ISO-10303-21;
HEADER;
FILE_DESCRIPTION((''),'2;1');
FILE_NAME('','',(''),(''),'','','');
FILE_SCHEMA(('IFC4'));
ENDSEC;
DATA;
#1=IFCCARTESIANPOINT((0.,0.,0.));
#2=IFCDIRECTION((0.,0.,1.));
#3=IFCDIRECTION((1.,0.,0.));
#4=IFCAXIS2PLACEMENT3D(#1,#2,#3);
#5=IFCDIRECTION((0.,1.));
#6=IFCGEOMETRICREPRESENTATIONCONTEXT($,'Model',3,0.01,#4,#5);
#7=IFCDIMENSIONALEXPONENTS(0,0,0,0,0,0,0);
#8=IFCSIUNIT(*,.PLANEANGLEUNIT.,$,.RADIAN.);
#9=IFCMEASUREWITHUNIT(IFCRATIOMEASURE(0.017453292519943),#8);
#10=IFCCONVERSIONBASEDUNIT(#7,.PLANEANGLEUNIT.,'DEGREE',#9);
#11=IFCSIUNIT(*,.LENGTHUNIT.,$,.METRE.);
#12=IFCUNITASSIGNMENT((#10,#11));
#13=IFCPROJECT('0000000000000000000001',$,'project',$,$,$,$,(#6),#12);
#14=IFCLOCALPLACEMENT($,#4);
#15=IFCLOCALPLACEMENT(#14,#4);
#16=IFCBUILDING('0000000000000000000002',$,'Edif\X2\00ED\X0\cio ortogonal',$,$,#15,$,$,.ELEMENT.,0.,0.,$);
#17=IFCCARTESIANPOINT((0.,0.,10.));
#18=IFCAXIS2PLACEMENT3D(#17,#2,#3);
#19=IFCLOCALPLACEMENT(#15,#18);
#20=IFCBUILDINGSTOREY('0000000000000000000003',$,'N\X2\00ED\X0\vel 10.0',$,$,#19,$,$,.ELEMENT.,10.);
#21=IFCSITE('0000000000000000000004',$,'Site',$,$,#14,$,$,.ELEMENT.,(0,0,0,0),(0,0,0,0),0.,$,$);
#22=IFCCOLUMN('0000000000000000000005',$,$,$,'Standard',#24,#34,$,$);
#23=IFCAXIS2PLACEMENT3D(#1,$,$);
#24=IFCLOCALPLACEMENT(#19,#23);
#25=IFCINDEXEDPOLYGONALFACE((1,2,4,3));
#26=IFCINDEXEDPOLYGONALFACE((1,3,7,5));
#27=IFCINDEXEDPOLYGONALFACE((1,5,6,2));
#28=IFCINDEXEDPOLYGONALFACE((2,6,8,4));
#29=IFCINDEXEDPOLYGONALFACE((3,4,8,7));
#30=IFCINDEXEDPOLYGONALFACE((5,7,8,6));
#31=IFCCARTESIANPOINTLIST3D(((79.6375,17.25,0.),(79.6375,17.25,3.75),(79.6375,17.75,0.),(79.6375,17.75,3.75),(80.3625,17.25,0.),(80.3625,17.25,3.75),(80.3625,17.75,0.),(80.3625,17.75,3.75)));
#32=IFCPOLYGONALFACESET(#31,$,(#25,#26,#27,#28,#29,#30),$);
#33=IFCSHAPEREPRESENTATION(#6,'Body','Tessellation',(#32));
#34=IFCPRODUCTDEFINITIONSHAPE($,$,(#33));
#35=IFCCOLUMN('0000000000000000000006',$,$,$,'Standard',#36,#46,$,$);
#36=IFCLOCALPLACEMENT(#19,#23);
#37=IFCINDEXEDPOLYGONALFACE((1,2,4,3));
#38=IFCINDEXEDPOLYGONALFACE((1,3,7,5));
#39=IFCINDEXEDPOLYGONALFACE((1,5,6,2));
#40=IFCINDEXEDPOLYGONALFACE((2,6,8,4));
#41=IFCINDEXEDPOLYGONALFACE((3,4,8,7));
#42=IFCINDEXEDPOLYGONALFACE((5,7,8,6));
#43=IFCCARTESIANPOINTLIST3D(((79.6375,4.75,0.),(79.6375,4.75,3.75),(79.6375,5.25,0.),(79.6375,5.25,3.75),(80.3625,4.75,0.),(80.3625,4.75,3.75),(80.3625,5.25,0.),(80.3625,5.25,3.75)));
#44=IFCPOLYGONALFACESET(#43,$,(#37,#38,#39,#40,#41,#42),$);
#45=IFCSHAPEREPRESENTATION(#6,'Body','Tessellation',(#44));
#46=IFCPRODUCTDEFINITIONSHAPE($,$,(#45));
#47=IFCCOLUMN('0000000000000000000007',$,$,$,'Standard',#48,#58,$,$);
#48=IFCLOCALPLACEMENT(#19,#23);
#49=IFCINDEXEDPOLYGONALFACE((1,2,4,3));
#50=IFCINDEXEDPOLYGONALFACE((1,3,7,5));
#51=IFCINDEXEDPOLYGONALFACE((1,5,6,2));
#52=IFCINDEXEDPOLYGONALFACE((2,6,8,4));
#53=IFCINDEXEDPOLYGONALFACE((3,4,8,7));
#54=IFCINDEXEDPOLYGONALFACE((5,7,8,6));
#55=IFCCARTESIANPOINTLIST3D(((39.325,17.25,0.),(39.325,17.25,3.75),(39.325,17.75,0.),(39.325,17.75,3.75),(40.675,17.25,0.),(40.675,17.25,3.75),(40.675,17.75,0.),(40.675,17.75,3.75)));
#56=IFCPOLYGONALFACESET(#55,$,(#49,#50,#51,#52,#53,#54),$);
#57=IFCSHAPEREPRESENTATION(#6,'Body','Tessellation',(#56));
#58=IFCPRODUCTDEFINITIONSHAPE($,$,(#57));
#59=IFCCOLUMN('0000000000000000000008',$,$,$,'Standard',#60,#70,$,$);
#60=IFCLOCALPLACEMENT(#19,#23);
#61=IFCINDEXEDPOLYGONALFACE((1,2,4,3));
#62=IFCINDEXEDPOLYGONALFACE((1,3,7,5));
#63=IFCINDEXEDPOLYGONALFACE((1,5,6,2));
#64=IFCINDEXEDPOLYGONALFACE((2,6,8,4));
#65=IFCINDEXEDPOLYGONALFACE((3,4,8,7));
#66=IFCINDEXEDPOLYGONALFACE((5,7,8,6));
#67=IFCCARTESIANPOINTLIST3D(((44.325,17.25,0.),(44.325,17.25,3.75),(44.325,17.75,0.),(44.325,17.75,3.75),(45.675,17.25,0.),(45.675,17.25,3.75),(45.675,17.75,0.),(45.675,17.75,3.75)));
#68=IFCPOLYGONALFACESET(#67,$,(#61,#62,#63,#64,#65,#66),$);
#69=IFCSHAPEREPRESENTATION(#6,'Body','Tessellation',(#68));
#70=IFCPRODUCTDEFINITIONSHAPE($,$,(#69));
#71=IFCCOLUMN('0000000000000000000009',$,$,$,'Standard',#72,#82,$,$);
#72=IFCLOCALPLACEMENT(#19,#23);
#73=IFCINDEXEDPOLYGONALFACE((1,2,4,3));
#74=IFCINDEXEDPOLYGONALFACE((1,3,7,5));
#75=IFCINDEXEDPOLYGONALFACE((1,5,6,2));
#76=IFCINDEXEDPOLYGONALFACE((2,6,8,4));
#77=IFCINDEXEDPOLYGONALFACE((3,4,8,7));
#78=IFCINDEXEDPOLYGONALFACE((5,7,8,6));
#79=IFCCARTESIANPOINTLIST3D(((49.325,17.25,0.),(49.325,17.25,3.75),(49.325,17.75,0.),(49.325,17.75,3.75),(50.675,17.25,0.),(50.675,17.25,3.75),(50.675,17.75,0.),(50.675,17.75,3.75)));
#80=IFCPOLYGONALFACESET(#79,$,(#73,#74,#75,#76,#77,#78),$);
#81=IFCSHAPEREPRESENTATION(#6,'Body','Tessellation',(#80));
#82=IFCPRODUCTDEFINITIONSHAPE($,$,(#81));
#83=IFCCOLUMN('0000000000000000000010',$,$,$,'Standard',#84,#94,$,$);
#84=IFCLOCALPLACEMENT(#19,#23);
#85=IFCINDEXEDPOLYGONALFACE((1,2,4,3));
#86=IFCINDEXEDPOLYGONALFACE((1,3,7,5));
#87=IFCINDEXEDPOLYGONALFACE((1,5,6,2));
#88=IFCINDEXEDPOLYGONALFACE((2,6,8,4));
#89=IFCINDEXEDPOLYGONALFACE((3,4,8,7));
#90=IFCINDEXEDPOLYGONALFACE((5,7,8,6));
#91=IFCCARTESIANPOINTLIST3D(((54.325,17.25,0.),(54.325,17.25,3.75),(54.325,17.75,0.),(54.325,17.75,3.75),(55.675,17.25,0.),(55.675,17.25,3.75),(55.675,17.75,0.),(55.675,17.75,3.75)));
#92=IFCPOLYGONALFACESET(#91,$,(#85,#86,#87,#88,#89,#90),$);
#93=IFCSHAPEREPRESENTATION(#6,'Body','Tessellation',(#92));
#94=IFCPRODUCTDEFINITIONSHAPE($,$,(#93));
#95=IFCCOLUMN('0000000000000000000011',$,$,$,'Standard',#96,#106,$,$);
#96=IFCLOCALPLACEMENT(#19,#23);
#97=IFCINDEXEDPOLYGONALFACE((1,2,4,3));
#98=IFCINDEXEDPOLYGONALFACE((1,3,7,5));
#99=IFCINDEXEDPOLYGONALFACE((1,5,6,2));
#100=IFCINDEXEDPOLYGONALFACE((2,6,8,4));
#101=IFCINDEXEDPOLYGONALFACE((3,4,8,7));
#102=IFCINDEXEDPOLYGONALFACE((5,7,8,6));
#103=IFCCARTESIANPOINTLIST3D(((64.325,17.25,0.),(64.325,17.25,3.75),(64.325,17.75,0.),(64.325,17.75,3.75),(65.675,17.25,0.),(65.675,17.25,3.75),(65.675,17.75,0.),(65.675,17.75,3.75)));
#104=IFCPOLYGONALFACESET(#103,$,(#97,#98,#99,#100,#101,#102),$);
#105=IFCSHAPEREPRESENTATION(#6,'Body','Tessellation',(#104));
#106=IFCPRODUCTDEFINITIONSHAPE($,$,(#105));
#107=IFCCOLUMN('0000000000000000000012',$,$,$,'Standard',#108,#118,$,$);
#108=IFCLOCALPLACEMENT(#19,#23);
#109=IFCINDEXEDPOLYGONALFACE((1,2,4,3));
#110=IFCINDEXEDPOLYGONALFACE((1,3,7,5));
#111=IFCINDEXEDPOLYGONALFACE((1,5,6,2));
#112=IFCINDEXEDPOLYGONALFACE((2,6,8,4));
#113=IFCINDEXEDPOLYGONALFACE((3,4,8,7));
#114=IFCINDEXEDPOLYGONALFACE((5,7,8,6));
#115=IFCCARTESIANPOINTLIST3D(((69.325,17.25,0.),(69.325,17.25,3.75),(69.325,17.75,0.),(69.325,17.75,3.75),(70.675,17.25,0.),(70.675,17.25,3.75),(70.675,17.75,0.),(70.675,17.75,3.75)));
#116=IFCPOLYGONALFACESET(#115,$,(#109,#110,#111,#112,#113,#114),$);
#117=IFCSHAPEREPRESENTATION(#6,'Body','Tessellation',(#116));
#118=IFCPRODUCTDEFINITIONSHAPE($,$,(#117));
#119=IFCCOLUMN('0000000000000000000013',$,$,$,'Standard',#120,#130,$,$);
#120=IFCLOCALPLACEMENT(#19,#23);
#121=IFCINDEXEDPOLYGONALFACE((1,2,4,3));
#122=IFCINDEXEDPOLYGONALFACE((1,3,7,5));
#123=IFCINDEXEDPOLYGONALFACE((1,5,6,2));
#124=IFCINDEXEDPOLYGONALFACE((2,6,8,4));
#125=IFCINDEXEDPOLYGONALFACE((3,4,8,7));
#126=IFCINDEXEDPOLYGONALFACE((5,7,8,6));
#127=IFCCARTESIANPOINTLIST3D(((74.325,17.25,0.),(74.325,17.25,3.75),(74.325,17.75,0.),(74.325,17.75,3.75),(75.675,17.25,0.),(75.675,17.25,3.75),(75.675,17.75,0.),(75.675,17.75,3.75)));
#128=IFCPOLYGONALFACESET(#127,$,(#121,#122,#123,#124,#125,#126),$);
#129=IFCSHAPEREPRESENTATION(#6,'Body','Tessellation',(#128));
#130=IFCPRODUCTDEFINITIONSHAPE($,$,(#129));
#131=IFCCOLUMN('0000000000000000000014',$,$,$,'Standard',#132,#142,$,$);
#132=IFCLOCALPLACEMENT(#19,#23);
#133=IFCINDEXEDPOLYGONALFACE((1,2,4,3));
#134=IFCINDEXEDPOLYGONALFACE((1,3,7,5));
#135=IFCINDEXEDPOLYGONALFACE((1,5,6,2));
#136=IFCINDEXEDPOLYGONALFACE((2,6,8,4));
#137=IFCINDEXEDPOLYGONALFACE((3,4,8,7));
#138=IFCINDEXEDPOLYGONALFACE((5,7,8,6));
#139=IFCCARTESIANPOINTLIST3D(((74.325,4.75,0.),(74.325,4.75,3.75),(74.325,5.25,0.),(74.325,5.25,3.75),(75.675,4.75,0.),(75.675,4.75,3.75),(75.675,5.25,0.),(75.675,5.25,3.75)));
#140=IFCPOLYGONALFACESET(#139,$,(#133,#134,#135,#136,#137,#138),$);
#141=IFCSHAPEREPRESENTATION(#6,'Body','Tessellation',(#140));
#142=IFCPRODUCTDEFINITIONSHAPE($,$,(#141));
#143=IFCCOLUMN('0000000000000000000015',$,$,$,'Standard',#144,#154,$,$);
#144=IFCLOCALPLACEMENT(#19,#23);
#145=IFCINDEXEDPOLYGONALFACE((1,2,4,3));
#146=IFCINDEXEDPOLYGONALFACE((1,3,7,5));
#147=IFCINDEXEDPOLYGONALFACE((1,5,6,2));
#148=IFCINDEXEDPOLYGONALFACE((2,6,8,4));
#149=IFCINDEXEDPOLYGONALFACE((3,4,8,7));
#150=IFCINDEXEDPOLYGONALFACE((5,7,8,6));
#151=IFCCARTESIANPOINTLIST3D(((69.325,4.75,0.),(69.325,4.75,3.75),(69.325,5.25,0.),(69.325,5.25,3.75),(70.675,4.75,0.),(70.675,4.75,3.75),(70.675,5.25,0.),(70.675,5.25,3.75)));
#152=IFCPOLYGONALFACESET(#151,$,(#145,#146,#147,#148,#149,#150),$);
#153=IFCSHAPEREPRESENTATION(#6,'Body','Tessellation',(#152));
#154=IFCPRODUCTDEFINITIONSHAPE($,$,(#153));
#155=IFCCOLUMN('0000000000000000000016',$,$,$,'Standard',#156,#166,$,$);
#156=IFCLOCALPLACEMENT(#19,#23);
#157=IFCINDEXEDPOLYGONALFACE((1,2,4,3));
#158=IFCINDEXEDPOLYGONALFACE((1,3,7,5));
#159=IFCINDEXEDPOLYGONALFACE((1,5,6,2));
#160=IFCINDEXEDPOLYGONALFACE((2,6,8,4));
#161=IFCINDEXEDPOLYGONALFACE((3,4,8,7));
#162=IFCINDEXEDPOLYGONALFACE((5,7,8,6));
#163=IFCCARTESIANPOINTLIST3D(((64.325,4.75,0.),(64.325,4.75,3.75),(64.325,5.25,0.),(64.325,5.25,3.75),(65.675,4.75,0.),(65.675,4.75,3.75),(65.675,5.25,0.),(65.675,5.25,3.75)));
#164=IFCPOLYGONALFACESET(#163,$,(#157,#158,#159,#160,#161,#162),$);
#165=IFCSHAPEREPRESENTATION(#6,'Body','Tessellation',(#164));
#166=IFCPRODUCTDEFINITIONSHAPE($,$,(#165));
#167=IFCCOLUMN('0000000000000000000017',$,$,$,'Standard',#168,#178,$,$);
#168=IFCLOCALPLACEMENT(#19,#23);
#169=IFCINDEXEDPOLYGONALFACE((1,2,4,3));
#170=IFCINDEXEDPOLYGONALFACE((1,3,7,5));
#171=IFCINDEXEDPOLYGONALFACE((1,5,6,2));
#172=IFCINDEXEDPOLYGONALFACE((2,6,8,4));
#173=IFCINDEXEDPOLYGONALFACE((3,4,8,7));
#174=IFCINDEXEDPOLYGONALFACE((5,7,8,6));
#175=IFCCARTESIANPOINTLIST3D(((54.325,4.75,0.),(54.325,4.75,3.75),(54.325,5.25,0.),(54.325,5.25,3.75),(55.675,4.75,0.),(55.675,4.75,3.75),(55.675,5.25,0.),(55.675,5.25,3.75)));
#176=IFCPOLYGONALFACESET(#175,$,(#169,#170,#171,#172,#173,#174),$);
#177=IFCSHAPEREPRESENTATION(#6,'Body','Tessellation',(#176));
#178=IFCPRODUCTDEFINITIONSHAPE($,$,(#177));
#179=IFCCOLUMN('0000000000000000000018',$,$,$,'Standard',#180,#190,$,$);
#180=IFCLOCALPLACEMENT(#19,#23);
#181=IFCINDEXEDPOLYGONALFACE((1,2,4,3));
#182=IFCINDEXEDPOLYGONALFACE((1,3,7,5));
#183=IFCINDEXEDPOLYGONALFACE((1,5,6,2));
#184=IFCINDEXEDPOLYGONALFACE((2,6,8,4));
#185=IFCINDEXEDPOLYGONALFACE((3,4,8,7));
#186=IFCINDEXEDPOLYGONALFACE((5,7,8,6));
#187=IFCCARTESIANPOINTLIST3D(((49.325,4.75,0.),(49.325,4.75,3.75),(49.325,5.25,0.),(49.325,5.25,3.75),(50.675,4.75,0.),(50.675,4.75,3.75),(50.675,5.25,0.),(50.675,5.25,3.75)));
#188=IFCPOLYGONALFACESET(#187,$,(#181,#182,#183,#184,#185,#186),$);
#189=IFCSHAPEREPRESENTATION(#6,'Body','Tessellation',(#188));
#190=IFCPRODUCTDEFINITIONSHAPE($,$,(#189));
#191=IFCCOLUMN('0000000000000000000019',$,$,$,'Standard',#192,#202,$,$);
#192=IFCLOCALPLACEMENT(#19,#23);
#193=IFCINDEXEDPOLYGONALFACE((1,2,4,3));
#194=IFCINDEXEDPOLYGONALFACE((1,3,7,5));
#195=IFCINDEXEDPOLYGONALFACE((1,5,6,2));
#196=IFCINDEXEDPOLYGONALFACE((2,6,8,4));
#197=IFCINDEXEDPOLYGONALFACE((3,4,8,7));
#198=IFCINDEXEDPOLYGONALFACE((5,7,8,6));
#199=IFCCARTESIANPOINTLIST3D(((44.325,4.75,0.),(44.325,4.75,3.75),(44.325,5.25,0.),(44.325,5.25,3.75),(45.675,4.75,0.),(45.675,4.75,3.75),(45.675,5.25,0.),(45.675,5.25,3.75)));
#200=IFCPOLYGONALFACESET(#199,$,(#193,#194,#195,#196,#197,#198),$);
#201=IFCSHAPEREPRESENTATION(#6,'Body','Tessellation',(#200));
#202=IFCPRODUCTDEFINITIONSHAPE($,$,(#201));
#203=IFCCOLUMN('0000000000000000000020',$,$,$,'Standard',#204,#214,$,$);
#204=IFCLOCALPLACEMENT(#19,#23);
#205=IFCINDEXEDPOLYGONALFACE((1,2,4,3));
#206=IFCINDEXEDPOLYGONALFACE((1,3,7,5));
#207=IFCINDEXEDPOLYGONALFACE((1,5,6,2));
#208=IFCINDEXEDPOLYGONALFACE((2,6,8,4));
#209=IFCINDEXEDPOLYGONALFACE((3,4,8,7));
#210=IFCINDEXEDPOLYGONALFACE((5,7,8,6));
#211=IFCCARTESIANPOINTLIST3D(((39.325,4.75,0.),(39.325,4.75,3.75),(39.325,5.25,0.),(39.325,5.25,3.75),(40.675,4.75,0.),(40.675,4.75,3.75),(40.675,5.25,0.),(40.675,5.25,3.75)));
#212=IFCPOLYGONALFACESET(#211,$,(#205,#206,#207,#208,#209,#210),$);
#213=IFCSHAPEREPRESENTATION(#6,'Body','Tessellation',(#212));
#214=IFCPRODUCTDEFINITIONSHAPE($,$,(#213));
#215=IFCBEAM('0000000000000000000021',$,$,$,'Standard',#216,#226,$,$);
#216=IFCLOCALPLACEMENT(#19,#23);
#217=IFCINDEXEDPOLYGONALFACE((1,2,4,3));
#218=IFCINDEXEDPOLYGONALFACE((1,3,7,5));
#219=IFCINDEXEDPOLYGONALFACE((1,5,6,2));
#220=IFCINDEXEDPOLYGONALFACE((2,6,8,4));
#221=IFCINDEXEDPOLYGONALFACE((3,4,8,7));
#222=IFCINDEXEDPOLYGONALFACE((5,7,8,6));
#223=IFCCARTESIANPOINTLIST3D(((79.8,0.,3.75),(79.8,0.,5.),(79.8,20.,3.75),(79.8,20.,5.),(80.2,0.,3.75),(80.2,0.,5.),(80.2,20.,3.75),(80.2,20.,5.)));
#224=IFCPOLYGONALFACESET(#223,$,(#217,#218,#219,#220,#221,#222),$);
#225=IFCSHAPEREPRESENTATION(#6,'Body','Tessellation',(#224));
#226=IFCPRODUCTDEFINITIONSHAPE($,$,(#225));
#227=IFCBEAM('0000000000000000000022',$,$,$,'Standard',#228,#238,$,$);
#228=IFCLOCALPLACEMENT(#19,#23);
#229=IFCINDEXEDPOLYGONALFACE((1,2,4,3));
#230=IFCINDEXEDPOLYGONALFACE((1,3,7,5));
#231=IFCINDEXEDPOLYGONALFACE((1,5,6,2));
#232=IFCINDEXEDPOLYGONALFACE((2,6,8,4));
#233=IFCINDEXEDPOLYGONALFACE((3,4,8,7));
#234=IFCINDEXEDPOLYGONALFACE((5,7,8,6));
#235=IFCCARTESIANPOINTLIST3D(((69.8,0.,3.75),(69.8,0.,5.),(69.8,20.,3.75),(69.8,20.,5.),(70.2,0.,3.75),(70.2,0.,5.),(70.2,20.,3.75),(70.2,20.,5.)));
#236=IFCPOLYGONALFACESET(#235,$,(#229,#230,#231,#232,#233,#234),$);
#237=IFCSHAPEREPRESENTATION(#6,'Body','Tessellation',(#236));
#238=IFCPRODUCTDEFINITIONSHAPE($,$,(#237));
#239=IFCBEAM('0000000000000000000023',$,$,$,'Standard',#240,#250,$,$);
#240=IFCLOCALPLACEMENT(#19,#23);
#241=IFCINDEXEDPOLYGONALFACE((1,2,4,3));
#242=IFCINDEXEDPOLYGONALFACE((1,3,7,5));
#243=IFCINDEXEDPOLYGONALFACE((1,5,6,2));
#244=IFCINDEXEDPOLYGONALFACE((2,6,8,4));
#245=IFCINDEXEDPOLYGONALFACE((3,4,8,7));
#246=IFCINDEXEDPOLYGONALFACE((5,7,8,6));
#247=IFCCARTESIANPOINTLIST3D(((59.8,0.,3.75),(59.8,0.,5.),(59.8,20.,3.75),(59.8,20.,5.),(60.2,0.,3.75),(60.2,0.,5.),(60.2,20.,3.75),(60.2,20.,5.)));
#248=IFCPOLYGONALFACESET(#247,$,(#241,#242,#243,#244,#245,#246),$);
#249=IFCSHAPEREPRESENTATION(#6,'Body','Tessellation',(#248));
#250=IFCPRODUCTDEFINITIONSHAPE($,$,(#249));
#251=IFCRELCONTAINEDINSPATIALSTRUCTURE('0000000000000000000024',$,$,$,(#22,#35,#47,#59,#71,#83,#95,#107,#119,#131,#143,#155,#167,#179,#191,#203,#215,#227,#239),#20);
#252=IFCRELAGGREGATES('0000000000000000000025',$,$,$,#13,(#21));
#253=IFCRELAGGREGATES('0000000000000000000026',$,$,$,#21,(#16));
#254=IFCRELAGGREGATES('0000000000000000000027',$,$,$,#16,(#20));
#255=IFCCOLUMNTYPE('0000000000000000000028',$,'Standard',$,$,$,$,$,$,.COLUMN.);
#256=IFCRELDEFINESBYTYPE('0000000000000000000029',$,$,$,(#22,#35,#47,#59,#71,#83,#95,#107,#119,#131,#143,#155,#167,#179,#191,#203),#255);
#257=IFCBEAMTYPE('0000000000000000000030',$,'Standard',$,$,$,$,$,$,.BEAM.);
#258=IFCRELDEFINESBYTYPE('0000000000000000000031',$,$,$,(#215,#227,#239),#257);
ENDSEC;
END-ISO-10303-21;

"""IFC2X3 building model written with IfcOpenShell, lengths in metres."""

from ifc_helpers import new_model, entity, si_unit, converted_unit, direction, frame, origin_with_axes, origin_2d, place, context, project, spatial, polyline, rectangle, outline, extrude, type_object, element, save


model = new_model("IFC2X3")

# Units and contexts
model_context = context("Model", 3, precision=0.01, world=origin_with_axes(), true_north=direction((0.0, 1.0)))
ifc_project = project(units=[converted_unit("PLANEANGLEUNIT", "DEGREE", entity("IfcRatioMeasure", 0.017453292519943), si_unit("PLANEANGLEUNIT", "RADIAN"), dimensions=[0, 0, 0, 0, 0, 0, 0]), si_unit("LENGTHUNIT", "METRE")], contexts=[model_context])

# Site, building, storey
site_placement = place(None, origin_with_axes())
site = spatial("IfcSite", under=ifc_project, at=site_placement, Name="Site", CompositionType="ELEMENT", RefLatitude=(0, 0, 0, 0), RefLongitude=(0, 0, 0, 0), RefElevation=0.0)
building_placement = place(site_placement, origin_with_axes())
building = spatial("IfcBuilding", under=site, at=building_placement, Name="Edifício ortogonal", CompositionType="ELEMENT", ElevationOfRefHeight=0.0, ElevationOfTerrain=0.0)
storey_placement = place(building_placement, frame((0.0, 0.0, 10.0), z_axis=(0.0, 0.0, 1.0), x_axis=(1.0, 0.0, 0.0)))
storey = spatial("IfcBuildingStorey", under=building, at=storey_placement, Name="Nível 10.0", CompositionType="ELEMENT", Elevation=10.0)

# Columns
column_type = type_object("IfcColumnType", Name="Standard", PredefinedType="COLUMN")
for number, where, z_axis, x_axis in (
    (1, (80.0, 17.5, 10.0), (0.0, 0.0, 1.0), (1.0, 0.0, 0.0)),
    (2, (80.0, 5.0, 10.0), (0.0, 0.0, 1.0), (1.0, 0.0, 0.0)),
):
    element("IfcColumn", number, at=place(site_placement, frame(where, z_axis=z_axis, x_axis=x_axis)), inside=storey, type_object=column_type, ObjectType="Standard", context=model_context, shape_type="SweptSolid", body=[
        extrude(outline(polyline([(0.3625, -0.25), (0.3625, 0.25), (-0.3625, 0.25), (-0.3625, -0.25), (0.3625, -0.25)])), origin_with_axes(), (0.0, 0.0, 1.0), 3.75),
    ])
for number, where, z_axis, x_axis in (
    (3, (40.0, 17.5, 10.0), (0.0, 0.0, 1.0), (1.0, 0.0, 0.0)),
    (4, (45.0, 17.5, 10.0), (0.0, 0.0, 1.0), (1.0, 0.0, 0.0)),
    (5, (50.0, 17.5, 10.0), (0.0, 0.0, 1.0), (1.0, 0.0, 0.0)),
    (6, (55.0, 17.5, 10.0), (0.0, 0.0, 1.0), (1.0, 0.0, 0.0)),
    (7, (65.0, 17.5, 10.0), (0.0, 0.0, 1.0), (1.0, 0.0, 0.0)),
    (8, (70.0, 17.5, 10.0), (0.0, 0.0, 1.0), (1.0, 0.0, 0.0)),
    (9, (75.0, 17.5, 10.0), (0.0, 0.0, 1.0), (1.0, 0.0, 0.0)),
    (10, (75.0, 5.0, 10.0), (0.0, 0.0, 1.0), (1.0, 0.0, 0.0)),
    (11, (70.0, 5.0, 10.0), (0.0, 0.0, 1.0), (1.0, 0.0, 0.0)),
    (12, (65.0, 5.0, 10.0), (0.0, 0.0, 1.0), (1.0, 0.0, 0.0)),
    (13, (55.0, 5.0, 10.0), (0.0, 0.0, 1.0), (1.0, 0.0, 0.0)),
    (14, (50.0, 5.0, 10.0), (0.0, 0.0, 1.0), (1.0, 0.0, 0.0)),
    (15, (45.0, 5.0, 10.0), (0.0, 0.0, 1.0), (1.0, 0.0, 0.0)),
    (16, (40.0, 5.0, 10.0), (0.0, 0.0, 1.0), (1.0, 0.0, 0.0)),
):
    element("IfcColumn", number, at=place(site_placement, frame(where, z_axis=z_axis, x_axis=x_axis)), inside=storey, type_object=column_type, ObjectType="Standard", context=model_context, shape_type="SweptSolid", body=[
        extrude(outline(polyline([(0.675, -0.25), (0.675, 0.25), (-0.675, 0.25), (-0.675, -0.25), (0.675, -0.25)])), origin_with_axes(), (0.0, 0.0, 1.0), 3.75),
    ])

# Beams
beam_type = type_object("IfcBeamType", Name="Standard", PredefinedType="BEAM")
for number, where, z_axis, x_axis in (
    (17, (80.0, 20.0, 15.0), (0.0, 0.0, 1.0), (0.0, -1.0, 0.0)),
    (18, (70.0, 20.0, 15.0), (0.0, 0.0, 1.0), (0.0, -1.0, 0.0)),
    (19, (60.0, 20.0, 15.0), (0.0, 0.0, 1.0), (0.0, -1.0, 0.0)),
):
    element("IfcBeam", number, at=place(site_placement, frame(where, z_axis=z_axis, x_axis=x_axis)), inside=storey, type_object=beam_type, ObjectType="Standard", context=model_context, shape_type="SweptSolid", body=[
        extrude(rectangle(XDim=0.4, YDim=1.25, at=origin_2d()), frame((0.0, 0.0, -0.625), z_axis=(1.0, 0.0, 0.0), x_axis=(0.0, 1.0, 0.0)), (0.0, 0.0, 1.0), 20.0),
    ])

save(model, "model.ifc")
